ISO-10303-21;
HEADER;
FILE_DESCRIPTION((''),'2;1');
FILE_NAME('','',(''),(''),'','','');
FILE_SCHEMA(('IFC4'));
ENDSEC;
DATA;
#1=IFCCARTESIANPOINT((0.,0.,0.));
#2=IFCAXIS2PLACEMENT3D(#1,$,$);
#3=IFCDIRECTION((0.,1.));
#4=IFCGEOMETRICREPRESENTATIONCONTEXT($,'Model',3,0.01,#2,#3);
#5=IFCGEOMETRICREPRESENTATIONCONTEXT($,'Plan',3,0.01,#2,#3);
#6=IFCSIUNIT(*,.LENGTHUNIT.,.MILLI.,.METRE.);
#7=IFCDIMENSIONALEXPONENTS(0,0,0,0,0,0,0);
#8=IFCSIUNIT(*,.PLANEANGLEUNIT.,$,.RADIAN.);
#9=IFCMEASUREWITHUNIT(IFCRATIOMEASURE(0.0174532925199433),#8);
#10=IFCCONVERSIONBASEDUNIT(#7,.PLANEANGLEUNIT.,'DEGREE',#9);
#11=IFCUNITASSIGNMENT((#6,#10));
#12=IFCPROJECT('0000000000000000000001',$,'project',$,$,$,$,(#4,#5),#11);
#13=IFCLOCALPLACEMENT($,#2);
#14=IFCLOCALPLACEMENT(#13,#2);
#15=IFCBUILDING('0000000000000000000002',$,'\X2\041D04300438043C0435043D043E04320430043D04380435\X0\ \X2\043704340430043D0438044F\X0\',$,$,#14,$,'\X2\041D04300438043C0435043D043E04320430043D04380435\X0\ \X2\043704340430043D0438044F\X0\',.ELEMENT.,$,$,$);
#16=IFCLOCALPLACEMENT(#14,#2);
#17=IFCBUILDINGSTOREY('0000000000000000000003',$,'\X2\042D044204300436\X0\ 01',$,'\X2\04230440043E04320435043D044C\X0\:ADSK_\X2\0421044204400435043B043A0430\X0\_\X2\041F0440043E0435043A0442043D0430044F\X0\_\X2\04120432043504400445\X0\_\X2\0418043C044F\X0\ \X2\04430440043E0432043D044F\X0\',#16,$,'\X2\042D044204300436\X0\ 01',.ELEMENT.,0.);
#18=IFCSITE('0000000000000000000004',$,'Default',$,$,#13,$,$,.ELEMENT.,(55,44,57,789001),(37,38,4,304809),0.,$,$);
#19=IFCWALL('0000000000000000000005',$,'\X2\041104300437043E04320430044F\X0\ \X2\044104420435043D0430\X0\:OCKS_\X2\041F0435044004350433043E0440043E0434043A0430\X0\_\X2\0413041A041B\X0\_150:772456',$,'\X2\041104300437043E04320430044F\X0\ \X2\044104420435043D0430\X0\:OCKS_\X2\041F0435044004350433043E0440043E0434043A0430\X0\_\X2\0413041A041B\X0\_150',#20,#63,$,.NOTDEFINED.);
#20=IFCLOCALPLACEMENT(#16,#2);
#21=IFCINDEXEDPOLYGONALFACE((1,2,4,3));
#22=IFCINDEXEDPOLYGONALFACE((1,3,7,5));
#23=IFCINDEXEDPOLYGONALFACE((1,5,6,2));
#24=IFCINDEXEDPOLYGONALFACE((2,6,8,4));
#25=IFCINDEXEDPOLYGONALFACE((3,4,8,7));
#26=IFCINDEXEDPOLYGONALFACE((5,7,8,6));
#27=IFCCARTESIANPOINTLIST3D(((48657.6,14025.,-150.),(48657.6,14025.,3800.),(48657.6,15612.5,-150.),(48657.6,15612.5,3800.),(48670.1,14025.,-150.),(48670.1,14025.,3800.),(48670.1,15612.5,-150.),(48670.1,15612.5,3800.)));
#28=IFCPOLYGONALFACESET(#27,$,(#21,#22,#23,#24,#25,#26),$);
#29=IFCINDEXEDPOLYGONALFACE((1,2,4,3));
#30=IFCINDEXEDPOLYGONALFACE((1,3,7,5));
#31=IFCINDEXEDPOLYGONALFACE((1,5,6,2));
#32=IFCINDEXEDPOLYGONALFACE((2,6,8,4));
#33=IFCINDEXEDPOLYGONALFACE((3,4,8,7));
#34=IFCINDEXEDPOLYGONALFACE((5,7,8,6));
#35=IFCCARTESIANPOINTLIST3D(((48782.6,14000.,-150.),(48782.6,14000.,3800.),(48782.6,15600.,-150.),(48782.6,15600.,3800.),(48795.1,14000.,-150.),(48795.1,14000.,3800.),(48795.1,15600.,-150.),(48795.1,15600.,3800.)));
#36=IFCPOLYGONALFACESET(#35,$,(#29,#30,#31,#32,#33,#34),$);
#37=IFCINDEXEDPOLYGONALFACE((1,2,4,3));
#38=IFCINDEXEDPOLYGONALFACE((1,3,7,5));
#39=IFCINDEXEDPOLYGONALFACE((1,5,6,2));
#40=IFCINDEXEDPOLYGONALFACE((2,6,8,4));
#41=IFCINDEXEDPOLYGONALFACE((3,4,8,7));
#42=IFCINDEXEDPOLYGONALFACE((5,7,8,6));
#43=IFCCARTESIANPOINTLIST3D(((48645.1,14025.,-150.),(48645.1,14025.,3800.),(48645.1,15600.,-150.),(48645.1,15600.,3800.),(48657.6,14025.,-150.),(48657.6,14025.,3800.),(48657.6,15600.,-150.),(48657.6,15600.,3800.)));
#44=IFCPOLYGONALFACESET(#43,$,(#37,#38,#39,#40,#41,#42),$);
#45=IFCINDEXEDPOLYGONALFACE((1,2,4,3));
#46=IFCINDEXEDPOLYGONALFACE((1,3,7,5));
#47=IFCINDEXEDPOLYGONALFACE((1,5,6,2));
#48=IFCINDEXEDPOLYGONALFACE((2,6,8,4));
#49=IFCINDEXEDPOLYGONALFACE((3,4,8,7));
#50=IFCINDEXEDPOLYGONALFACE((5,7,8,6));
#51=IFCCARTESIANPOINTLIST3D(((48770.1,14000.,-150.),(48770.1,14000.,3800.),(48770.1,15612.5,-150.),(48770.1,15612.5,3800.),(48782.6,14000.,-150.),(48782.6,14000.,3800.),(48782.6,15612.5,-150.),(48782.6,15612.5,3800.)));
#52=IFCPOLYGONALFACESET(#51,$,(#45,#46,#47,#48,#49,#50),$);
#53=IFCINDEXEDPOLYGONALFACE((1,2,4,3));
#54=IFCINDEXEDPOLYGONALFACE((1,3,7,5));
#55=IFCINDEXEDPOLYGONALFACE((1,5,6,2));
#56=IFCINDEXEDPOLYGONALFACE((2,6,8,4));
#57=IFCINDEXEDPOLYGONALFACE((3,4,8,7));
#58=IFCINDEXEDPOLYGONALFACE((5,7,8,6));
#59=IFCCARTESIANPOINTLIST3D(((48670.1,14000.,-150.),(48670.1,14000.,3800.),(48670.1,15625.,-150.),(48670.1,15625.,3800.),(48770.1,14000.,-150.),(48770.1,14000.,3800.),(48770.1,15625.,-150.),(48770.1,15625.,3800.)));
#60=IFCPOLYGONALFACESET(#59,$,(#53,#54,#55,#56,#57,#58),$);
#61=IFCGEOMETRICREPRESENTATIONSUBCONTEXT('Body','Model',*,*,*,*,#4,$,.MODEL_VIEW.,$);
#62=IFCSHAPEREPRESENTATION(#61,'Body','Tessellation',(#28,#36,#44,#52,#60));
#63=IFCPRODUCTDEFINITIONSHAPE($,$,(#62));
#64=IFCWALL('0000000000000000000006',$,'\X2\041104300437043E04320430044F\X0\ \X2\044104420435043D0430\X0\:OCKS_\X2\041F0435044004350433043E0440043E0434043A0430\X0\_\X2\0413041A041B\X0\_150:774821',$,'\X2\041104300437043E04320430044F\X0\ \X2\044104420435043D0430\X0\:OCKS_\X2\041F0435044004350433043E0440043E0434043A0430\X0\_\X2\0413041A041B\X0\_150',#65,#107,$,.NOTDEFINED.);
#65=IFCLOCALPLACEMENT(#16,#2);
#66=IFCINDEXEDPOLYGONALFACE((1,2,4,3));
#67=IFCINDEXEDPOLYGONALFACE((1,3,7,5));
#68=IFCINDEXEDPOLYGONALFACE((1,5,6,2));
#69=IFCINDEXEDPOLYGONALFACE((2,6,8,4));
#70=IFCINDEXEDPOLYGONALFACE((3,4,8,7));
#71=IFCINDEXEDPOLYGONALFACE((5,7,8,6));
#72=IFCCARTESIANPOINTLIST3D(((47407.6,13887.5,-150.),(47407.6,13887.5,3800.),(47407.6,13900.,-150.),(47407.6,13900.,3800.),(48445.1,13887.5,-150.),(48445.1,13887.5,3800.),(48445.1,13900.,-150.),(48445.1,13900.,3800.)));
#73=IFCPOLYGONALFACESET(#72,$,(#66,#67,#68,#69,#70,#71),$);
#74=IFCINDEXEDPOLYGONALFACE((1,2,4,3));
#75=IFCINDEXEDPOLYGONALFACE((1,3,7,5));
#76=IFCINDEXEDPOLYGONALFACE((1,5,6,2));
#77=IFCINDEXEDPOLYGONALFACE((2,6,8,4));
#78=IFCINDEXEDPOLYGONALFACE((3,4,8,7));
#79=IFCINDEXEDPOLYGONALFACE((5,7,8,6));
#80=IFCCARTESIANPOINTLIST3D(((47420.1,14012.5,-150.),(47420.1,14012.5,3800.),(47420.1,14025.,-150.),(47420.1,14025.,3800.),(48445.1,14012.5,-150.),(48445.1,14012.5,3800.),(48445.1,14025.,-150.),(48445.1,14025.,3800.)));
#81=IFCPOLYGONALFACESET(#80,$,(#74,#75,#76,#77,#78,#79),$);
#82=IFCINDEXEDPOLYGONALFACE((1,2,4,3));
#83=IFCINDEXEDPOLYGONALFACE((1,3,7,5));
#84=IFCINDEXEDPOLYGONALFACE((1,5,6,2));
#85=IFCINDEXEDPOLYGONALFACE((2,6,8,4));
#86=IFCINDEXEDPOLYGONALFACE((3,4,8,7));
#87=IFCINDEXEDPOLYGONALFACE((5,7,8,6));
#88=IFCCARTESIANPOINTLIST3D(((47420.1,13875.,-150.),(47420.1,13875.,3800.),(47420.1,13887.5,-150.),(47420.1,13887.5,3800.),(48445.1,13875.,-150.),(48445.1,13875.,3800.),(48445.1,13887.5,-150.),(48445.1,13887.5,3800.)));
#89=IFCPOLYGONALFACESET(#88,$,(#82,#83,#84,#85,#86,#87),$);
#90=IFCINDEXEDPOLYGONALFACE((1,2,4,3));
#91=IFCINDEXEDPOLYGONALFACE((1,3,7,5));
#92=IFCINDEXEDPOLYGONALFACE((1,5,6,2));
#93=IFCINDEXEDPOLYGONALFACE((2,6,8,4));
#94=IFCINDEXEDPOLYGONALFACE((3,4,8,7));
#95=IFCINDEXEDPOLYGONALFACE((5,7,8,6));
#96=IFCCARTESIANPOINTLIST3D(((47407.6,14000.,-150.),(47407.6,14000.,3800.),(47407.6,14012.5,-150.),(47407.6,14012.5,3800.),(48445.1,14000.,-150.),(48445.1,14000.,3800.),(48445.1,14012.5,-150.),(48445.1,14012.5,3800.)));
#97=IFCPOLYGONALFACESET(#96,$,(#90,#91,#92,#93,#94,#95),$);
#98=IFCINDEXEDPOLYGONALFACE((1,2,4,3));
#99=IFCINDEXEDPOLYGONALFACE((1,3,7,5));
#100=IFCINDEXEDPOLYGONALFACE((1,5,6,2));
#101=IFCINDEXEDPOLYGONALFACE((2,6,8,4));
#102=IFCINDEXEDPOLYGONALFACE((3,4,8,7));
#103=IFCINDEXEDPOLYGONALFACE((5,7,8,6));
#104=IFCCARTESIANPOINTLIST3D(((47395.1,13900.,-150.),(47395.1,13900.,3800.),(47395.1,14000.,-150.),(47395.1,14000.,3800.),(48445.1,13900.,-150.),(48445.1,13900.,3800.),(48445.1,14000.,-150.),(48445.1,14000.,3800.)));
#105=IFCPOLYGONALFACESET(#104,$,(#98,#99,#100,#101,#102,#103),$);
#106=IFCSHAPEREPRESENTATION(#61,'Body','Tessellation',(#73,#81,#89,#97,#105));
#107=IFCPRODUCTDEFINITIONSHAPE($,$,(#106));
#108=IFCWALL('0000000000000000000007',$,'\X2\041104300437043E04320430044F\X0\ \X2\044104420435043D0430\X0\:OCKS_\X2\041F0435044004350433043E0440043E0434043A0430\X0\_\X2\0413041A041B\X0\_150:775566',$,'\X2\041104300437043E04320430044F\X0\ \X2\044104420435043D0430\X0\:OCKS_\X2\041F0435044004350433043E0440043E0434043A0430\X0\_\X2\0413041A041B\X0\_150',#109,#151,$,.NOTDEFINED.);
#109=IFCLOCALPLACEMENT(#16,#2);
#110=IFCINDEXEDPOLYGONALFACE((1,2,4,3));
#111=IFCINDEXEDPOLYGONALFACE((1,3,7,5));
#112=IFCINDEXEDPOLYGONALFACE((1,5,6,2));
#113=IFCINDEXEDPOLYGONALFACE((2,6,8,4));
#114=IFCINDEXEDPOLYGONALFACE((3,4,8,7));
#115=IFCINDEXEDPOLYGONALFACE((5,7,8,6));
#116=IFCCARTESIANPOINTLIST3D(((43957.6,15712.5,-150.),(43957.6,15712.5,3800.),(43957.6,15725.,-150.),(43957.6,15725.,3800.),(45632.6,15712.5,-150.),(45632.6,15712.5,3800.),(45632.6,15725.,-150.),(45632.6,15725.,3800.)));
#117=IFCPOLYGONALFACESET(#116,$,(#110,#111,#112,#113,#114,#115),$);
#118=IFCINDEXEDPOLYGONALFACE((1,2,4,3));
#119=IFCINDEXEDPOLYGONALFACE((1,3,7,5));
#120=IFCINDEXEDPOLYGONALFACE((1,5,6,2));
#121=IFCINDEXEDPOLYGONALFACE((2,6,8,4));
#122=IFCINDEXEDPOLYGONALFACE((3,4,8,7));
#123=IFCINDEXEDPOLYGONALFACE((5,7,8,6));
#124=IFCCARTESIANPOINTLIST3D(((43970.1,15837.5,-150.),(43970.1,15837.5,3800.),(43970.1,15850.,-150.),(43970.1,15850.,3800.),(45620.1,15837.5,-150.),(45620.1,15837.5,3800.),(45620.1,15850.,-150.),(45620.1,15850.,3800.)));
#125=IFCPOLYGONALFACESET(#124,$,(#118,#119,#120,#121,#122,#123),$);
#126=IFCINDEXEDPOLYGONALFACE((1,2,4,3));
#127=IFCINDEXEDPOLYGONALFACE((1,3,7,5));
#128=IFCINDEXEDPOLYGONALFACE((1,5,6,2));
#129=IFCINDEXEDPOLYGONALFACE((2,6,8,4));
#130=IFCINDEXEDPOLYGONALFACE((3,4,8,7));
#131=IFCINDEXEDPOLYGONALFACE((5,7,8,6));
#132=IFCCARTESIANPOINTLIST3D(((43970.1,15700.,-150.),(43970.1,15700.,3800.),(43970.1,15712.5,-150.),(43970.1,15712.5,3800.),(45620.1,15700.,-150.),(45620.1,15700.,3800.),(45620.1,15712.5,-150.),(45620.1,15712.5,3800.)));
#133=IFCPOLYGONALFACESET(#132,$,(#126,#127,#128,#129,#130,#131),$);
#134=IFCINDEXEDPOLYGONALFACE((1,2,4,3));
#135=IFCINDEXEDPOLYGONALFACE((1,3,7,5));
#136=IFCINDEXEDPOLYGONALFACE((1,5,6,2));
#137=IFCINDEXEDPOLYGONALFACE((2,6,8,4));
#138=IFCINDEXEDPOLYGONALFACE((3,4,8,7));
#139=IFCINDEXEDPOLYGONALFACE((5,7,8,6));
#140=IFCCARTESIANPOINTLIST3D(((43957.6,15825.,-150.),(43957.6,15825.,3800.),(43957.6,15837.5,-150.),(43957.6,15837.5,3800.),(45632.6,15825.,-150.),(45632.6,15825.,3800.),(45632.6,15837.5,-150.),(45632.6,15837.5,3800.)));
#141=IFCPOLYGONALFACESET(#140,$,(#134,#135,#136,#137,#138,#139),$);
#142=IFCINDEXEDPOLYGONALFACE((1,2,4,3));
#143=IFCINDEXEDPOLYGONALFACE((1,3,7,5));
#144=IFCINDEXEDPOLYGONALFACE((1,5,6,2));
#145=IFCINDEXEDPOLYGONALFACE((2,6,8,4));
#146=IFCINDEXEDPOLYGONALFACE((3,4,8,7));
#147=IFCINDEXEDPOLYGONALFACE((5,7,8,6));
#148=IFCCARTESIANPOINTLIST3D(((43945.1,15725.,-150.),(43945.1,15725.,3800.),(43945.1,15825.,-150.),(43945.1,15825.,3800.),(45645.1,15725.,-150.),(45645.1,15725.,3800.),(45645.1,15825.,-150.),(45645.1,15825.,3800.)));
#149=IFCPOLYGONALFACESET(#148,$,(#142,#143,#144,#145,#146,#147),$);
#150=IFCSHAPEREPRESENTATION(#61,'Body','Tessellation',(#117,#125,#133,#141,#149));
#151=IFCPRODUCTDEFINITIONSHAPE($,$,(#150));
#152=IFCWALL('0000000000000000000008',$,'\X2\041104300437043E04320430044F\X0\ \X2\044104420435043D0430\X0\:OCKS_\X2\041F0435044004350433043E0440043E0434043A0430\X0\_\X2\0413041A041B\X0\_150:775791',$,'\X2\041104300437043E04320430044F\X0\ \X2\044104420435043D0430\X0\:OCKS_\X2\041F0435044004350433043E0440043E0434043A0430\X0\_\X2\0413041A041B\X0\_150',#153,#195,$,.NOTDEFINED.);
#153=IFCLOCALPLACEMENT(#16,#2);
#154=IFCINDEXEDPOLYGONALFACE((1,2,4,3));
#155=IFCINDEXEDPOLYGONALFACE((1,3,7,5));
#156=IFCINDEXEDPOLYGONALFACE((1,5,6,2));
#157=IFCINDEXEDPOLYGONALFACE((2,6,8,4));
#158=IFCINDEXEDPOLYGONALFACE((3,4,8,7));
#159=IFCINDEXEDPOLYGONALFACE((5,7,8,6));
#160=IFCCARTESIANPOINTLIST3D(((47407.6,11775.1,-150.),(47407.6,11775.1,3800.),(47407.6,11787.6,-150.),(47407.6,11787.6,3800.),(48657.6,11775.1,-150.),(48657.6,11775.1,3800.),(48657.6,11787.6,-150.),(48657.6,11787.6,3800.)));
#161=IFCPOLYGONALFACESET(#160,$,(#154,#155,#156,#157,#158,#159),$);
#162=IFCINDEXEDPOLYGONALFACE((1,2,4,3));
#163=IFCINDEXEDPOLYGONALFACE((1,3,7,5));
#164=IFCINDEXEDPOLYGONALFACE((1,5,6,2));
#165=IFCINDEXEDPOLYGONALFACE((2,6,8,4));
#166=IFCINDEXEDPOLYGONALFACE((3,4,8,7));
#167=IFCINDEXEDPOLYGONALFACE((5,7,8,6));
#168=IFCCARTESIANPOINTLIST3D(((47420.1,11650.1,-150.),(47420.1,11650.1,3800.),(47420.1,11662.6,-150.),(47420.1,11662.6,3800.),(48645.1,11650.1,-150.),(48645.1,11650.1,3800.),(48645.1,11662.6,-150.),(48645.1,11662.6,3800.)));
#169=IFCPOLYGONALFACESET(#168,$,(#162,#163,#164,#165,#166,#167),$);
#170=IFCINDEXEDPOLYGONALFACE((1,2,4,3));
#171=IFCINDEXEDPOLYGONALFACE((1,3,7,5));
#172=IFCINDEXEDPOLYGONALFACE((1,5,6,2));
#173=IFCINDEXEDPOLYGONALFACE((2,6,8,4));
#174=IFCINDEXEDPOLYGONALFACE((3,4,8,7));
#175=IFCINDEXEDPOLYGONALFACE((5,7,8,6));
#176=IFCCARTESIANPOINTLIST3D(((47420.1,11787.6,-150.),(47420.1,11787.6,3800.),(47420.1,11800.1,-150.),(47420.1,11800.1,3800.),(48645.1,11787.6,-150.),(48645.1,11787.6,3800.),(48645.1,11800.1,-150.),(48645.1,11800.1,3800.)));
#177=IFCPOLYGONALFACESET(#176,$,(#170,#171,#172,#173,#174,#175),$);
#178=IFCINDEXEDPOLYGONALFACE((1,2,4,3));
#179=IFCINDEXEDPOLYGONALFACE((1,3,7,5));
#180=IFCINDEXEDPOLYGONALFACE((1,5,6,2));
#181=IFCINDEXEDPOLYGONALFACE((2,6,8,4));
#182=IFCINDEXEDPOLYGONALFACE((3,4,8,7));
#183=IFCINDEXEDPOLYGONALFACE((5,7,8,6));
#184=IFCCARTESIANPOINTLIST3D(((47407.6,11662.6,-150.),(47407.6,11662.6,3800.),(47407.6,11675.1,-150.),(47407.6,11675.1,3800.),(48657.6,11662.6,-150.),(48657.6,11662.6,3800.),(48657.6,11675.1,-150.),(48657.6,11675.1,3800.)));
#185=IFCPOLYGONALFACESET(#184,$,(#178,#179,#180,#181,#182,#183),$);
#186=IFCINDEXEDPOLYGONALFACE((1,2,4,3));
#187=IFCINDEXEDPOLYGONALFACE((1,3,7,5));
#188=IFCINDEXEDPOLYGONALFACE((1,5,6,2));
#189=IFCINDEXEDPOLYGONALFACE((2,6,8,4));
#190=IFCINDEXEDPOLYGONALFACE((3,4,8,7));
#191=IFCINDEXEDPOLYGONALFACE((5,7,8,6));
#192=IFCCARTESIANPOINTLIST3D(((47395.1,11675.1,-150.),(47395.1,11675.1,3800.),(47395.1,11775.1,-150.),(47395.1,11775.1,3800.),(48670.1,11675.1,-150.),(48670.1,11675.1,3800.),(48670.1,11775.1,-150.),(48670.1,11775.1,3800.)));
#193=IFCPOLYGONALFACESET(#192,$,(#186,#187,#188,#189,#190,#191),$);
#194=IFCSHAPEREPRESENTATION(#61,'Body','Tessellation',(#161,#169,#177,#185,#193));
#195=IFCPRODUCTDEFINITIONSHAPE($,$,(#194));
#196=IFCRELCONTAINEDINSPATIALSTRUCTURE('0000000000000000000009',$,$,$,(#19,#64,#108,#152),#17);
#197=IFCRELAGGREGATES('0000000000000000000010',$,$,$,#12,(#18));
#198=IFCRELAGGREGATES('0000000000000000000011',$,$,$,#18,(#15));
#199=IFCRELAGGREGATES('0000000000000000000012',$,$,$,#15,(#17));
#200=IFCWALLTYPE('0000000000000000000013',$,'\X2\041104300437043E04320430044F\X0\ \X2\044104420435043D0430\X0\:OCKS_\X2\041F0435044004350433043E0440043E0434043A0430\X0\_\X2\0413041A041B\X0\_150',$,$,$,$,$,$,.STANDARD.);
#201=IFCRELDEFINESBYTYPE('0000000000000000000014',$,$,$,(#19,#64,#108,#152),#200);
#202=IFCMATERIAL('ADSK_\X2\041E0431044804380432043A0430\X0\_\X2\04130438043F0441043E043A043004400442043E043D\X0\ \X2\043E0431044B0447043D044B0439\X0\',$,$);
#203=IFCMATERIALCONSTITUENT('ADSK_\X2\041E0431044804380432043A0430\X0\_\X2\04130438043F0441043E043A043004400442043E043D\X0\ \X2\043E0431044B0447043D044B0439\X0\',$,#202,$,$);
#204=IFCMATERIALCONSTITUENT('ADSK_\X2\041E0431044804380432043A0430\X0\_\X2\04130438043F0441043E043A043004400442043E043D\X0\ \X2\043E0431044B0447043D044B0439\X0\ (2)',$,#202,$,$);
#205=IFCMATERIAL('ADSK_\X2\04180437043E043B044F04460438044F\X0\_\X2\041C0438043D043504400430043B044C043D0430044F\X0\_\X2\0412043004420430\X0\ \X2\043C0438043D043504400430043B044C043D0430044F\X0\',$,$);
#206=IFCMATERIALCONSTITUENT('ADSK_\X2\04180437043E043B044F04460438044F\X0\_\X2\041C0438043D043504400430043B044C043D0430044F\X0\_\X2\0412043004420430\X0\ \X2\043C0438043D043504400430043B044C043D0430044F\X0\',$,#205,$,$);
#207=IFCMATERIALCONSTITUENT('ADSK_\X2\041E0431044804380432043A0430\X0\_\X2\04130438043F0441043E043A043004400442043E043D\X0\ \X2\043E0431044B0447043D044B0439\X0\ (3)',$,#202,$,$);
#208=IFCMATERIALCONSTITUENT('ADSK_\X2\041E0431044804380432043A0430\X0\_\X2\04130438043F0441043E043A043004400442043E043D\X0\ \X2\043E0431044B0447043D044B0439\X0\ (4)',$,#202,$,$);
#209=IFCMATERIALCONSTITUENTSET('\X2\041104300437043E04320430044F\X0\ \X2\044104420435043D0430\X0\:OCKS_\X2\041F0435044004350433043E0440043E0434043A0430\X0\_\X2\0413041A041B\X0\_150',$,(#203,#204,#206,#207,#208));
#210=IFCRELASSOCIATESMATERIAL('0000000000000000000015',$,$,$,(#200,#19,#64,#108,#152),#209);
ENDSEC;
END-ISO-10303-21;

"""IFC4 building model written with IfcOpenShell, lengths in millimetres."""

from ifc_helpers import new_model, entity, si_unit, converted_unit, direction, frame, origin, place, context, subcontext, project, spatial, indexed_curve, outline, extrude, material, constituent, constituent_set, type_object, element, save


model = new_model("IFC4")

# Units and contexts
model_context = context("Model", 3, precision=0.01, world=origin(), true_north=direction((0.0, 1.0)))
plan_context = context("Plan", 3, precision=0.01, world=origin(), true_north=direction((0.0, 1.0)))
body_context = subcontext(model_context, "Body", "Model", "MODEL_VIEW")
ifc_project = project(units=[si_unit("LENGTHUNIT", "METRE", prefix="MILLI"), converted_unit("PLANEANGLEUNIT", "DEGREE", entity("IfcRatioMeasure", 0.0174532925199433), si_unit("PLANEANGLEUNIT", "RADIAN"), dimensions=[0, 0, 0, 0, 0, 0, 0])], contexts=[model_context, plan_context])

# Site, building, storey
site_placement = place(None, frame((0.0, 0.0, 0.0)))
site = spatial("IfcSite", under=ifc_project, at=site_placement, Name="Default", CompositionType="ELEMENT", RefLatitude=(55, 44, 57, 789001), RefLongitude=(37, 38, 4, 304809), RefElevation=0.0)
building_placement = place(site_placement, origin())
building = spatial("IfcBuilding", under=site, at=building_placement, Name="Наименование здания", LongName="Наименование здания", CompositionType="ELEMENT")
storey_placement = place(building_placement, origin())
storey = spatial("IfcBuildingStorey", under=building, at=storey_placement, Name="Этаж 01", ObjectType="Уровень:ADSK_Стрелка_Проектная_Вверх_Имя уровня", LongName="Этаж 01", CompositionType="ELEMENT", Elevation=0.0)

# Shared definitions
ifc_material_1 = material(Name="ADSK_Обшивка_Гипсокартон обычный")
ifc_constituent_1 = constituent(ifc_material_1, Name="ADSK_Обшивка_Гипсокартон обычный")
ifc_constituent_2 = constituent(ifc_material_1, Name="ADSK_Обшивка_Гипсокартон обычный (2)")
ifc_material_2 = material(Name="ADSK_Изоляция_Минеральная_Вата минеральная")
ifc_constituent_3 = constituent(ifc_material_2, Name="ADSK_Изоляция_Минеральная_Вата минеральная")
ifc_constituent_4 = constituent(ifc_material_1, Name="ADSK_Обшивка_Гипсокартон обычный (3)")
ifc_constituent_5 = constituent(ifc_material_1, Name="ADSK_Обшивка_Гипсокартон обычный (4)")
ifc_constituent_set_1 = constituent_set(constituents=[ifc_constituent_1, ifc_constituent_2, ifc_constituent_3, ifc_constituent_4, ifc_constituent_5], Name="Базовая стена:OCKS_Перегородка_ГКЛ_150")
wall_type_1 = type_object("IfcWallType", Name="Базовая стена:OCKS_Перегородка_ГКЛ_150", PredefinedType="STANDARD", material=ifc_constituent_set_1)

# Walls
wall_1_placement = place(storey_placement, frame((48720.1, 15600.0, -150.0), z_axis=(0.0, 0.0, 1.0), x_axis=(0.0, -1.0, 0.0)))
element("IfcWall", 1, at=wall_1_placement, inside=storey, type_object=wall_type_1, material=ifc_constituent_set_1, Name="Базовая стена:OCKS_Перегородка_ГКЛ_150:772456", ObjectType="Базовая стена:OCKS_Перегородка_ГКЛ_150", PredefinedType="NOTDEFINED", context=body_context, shape_type="SweptSolid", body=[
    extrude(outline(indexed_curve([(-793.7, -6.3), (793.7, -6.3), (793.7, 6.3), (-793.7, 6.3), (-793.7, -6.3)], self_intersect=False)), frame((781.2, -56.3, 0.0)), (0.0, 0.0, 1.0), 3950.0),
    extrude(outline(indexed_curve([(-6.2, -800.0), (6.3, -800.0), (6.3, 800.0), (-6.2, 800.0), (-6.2, -800.0)], self_intersect=False)), frame((800.0, 68.8, 0.0), z_axis=(0.0, 0.0, 1.0), x_axis=(0.0, -1.0, 0.0)), (0.0, 0.0, 1.0), 3950.0),
    extrude(outline(indexed_curve([(-6.2, -787.5), (6.3, -787.5), (6.3, 787.5), (-6.2, 787.5), (-6.2, -787.5)], self_intersect=False)), frame((787.5, -68.8, 0.0), z_axis=(0.0, 0.0, 1.0), x_axis=(0.0, 1.0, 0.0)), (0.0, 0.0, 1.0), 3950.0),
    extrude(outline(indexed_curve([(-806.2, -6.3), (806.2, -6.3), (806.2, 6.3), (-806.2, 6.3), (-806.2, -6.3)], self_intersect=False)), frame((793.7, 56.3, 0.0)), (0.0, 0.0, 1.0), 3950.0),
    extrude(outline(indexed_curve([(-812.5, -50.0), (812.5, -50.0), (812.5, 50.0), (-812.5, 50.0), (-812.5, -50.0)], self_intersect=False)), frame((787.5, 0.0, 0.0)), (0.0, 0.0, 1.0), 3950.0),
])
wall_2_placement = place(storey_placement, frame((47420.1, 13950.0, -150.0)))
element("IfcWall", 2, at=wall_2_placement, inside=storey, type_object=wall_type_1, material=ifc_constituent_set_1, Name="Базовая стена:OCKS_Перегородка_ГКЛ_150:774821", ObjectType="Базовая стена:OCKS_Перегородка_ГКЛ_150", PredefinedType="NOTDEFINED", context=body_context, shape_type="SweptSolid", body=[
    extrude(outline(indexed_curve([(-518.7, -6.3), (518.7, -6.3), (518.7, 6.3), (-518.7, 6.3), (-518.7, -6.3)], self_intersect=False)), frame((506.2, -56.3, 0.0)), (0.0, 0.0, 1.0), 3950.0),
    extrude(outline(indexed_curve([(-6.3, -512.5), (6.2, -512.5), (6.3, 512.5), (-6.2, 512.5), (-6.3, -512.5)], self_intersect=False)), frame((512.5, 68.7, 0.0), z_axis=(0.0, 0.0, 1.0), x_axis=(0.0, -1.0, 0.0)), (0.0, 0.0, 1.0), 3950.0),
    extrude(outline(indexed_curve([(-6.3, -512.5), (6.2, -512.5), (6.3, 512.5), (-6.2, 512.5), (-6.3, -512.5)], self_intersect=False)), frame((512.5, -68.7, 0.0), z_axis=(0.0, 0.0, 1.0), x_axis=(0.0, 1.0, 0.0)), (0.0, 0.0, 1.0), 3950.0),
    extrude(outline(indexed_curve([(-518.7, -6.3), (518.7, -6.3), (518.7, 6.3), (-518.7, 6.3), (-518.7, -6.3)], self_intersect=False)), frame((506.2, 56.3, 0.0)), (0.0, 0.0, 1.0), 3950.0),
    extrude(outline(indexed_curve([(-525.0, -50.0), (525.0, -50.0), (525.0, 50.0), (-525.0, 50.0), (-525.0, -50.0)], self_intersect=False)), frame((500.0, 0.0, 0.0)), (0.0, 0.0, 1.0), 3950.0),
])

# Walls
wall_3_placement = place(storey_placement, frame((45620.1, 15775.0, -150.0), z_axis=(0.0, 0.0, 1.0), x_axis=(-1.0, 0.0, 0.0)))
element("IfcWall", 3, at=wall_3_placement, inside=storey, type_object=wall_type_1, material=ifc_constituent_set_1, Name="Базовая стена:OCKS_Перегородка_ГКЛ_150:775566", ObjectType="Базовая стена:OCKS_Перегородка_ГКЛ_150", PredefinedType="NOTDEFINED", context=body_context, shape_type="SweptSolid", body=[
    extrude(outline(indexed_curve([(-837.5, -6.3), (837.5, -6.3), (837.5, 6.3), (-837.5, 6.3), (-837.5, -6.3)], self_intersect=False)), frame((825.0, 56.3, 0.0)), (0.0, 0.0, 1.0), 3950.0),
    extrude(outline(indexed_curve([(-6.3, -825.0), (6.2, -825.0), (6.3, 825.0), (-6.2, 825.0), (-6.3, -825.0)], self_intersect=False)), frame((825.0, -68.7, 0.0), z_axis=(0.0, 0.0, 1.0), x_axis=(0.0, 1.0, 0.0)), (0.0, 0.0, 1.0), 3950.0),
    extrude(outline(indexed_curve([(-6.3, -825.0), (6.2, -825.0), (6.3, 825.0), (-6.2, 825.0), (-6.3, -825.0)], self_intersect=False)), frame((825.0, 68.7, 0.0), z_axis=(0.0, 0.0, 1.0), x_axis=(0.0, -1.0, 0.0)), (0.0, 0.0, 1.0), 3950.0),
    extrude(outline(indexed_curve([(-837.5, -6.3), (837.5, -6.3), (837.5, 6.3), (-837.5, 6.3), (-837.5, -6.3)], self_intersect=False)), frame((825.0, -56.3, 0.0)), (0.0, 0.0, 1.0), 3950.0),
    extrude(outline(indexed_curve([(-850.0, -50.0), (850.0, -50.0), (850.0, 50.0), (-850.0, 50.0), (-850.0, -50.0)], self_intersect=False)), frame((825.0, 0.0, 0.0)), (0.0, 0.0, 1.0), 3950.0),
])
wall_4_placement = place(storey_placement, frame((47420.1, 11725.1, -150.0)))
element("IfcWall", 4, at=wall_4_placement, inside=storey, type_object=wall_type_1, material=ifc_constituent_set_1, Name="Базовая стена:OCKS_Перегородка_ГКЛ_150:775791", ObjectType="Базовая стена:OCKS_Перегородка_ГКЛ_150", PredefinedType="NOTDEFINED", context=body_context, shape_type="SweptSolid", body=[
    extrude(outline(indexed_curve([(-625.0, -6.3), (625.0, -6.3), (625.0, 6.3), (-625.0, 6.3), (-625.0, -6.3)], self_intersect=False)), frame((612.5, 56.3, 0.0)), (0.0, 0.0, 1.0), 3950.0),
    extrude(outline(indexed_curve([(-6.3, -612.5), (6.2, -612.5), (6.3, 612.5), (-6.2, 612.5), (-6.3, -612.5)], self_intersect=False)), frame((612.5, -68.7, 0.0), z_axis=(0.0, 0.0, 1.0), x_axis=(0.0, 1.0, 0.0)), (0.0, 0.0, 1.0), 3950.0),
    extrude(outline(indexed_curve([(-6.3, -612.5), (6.2, -612.5), (6.3, 612.5), (-6.2, 612.5), (-6.3, -612.5)], self_intersect=False)), frame((612.5, 68.7, 0.0), z_axis=(0.0, 0.0, 1.0), x_axis=(0.0, -1.0, 0.0)), (0.0, 0.0, 1.0), 3950.0),
    extrude(outline(indexed_curve([(-625.0, -6.3), (625.0, -6.3), (625.0, 6.3), (-625.0, 6.3), (-625.0, -6.3)], self_intersect=False)), frame((612.5, -56.3, 0.0)), (0.0, 0.0, 1.0), 3950.0),
    extrude(outline(indexed_curve([(-637.5, -50.0), (637.5, -50.0), (637.5, 50.0), (-637.5, 50.0), (-637.5, -50.0)], self_intersect=False)), frame((612.5, 0.0, 0.0)), (0.0, 0.0, 1.0), 3950.0),
])

save(model, "model.ifc")
